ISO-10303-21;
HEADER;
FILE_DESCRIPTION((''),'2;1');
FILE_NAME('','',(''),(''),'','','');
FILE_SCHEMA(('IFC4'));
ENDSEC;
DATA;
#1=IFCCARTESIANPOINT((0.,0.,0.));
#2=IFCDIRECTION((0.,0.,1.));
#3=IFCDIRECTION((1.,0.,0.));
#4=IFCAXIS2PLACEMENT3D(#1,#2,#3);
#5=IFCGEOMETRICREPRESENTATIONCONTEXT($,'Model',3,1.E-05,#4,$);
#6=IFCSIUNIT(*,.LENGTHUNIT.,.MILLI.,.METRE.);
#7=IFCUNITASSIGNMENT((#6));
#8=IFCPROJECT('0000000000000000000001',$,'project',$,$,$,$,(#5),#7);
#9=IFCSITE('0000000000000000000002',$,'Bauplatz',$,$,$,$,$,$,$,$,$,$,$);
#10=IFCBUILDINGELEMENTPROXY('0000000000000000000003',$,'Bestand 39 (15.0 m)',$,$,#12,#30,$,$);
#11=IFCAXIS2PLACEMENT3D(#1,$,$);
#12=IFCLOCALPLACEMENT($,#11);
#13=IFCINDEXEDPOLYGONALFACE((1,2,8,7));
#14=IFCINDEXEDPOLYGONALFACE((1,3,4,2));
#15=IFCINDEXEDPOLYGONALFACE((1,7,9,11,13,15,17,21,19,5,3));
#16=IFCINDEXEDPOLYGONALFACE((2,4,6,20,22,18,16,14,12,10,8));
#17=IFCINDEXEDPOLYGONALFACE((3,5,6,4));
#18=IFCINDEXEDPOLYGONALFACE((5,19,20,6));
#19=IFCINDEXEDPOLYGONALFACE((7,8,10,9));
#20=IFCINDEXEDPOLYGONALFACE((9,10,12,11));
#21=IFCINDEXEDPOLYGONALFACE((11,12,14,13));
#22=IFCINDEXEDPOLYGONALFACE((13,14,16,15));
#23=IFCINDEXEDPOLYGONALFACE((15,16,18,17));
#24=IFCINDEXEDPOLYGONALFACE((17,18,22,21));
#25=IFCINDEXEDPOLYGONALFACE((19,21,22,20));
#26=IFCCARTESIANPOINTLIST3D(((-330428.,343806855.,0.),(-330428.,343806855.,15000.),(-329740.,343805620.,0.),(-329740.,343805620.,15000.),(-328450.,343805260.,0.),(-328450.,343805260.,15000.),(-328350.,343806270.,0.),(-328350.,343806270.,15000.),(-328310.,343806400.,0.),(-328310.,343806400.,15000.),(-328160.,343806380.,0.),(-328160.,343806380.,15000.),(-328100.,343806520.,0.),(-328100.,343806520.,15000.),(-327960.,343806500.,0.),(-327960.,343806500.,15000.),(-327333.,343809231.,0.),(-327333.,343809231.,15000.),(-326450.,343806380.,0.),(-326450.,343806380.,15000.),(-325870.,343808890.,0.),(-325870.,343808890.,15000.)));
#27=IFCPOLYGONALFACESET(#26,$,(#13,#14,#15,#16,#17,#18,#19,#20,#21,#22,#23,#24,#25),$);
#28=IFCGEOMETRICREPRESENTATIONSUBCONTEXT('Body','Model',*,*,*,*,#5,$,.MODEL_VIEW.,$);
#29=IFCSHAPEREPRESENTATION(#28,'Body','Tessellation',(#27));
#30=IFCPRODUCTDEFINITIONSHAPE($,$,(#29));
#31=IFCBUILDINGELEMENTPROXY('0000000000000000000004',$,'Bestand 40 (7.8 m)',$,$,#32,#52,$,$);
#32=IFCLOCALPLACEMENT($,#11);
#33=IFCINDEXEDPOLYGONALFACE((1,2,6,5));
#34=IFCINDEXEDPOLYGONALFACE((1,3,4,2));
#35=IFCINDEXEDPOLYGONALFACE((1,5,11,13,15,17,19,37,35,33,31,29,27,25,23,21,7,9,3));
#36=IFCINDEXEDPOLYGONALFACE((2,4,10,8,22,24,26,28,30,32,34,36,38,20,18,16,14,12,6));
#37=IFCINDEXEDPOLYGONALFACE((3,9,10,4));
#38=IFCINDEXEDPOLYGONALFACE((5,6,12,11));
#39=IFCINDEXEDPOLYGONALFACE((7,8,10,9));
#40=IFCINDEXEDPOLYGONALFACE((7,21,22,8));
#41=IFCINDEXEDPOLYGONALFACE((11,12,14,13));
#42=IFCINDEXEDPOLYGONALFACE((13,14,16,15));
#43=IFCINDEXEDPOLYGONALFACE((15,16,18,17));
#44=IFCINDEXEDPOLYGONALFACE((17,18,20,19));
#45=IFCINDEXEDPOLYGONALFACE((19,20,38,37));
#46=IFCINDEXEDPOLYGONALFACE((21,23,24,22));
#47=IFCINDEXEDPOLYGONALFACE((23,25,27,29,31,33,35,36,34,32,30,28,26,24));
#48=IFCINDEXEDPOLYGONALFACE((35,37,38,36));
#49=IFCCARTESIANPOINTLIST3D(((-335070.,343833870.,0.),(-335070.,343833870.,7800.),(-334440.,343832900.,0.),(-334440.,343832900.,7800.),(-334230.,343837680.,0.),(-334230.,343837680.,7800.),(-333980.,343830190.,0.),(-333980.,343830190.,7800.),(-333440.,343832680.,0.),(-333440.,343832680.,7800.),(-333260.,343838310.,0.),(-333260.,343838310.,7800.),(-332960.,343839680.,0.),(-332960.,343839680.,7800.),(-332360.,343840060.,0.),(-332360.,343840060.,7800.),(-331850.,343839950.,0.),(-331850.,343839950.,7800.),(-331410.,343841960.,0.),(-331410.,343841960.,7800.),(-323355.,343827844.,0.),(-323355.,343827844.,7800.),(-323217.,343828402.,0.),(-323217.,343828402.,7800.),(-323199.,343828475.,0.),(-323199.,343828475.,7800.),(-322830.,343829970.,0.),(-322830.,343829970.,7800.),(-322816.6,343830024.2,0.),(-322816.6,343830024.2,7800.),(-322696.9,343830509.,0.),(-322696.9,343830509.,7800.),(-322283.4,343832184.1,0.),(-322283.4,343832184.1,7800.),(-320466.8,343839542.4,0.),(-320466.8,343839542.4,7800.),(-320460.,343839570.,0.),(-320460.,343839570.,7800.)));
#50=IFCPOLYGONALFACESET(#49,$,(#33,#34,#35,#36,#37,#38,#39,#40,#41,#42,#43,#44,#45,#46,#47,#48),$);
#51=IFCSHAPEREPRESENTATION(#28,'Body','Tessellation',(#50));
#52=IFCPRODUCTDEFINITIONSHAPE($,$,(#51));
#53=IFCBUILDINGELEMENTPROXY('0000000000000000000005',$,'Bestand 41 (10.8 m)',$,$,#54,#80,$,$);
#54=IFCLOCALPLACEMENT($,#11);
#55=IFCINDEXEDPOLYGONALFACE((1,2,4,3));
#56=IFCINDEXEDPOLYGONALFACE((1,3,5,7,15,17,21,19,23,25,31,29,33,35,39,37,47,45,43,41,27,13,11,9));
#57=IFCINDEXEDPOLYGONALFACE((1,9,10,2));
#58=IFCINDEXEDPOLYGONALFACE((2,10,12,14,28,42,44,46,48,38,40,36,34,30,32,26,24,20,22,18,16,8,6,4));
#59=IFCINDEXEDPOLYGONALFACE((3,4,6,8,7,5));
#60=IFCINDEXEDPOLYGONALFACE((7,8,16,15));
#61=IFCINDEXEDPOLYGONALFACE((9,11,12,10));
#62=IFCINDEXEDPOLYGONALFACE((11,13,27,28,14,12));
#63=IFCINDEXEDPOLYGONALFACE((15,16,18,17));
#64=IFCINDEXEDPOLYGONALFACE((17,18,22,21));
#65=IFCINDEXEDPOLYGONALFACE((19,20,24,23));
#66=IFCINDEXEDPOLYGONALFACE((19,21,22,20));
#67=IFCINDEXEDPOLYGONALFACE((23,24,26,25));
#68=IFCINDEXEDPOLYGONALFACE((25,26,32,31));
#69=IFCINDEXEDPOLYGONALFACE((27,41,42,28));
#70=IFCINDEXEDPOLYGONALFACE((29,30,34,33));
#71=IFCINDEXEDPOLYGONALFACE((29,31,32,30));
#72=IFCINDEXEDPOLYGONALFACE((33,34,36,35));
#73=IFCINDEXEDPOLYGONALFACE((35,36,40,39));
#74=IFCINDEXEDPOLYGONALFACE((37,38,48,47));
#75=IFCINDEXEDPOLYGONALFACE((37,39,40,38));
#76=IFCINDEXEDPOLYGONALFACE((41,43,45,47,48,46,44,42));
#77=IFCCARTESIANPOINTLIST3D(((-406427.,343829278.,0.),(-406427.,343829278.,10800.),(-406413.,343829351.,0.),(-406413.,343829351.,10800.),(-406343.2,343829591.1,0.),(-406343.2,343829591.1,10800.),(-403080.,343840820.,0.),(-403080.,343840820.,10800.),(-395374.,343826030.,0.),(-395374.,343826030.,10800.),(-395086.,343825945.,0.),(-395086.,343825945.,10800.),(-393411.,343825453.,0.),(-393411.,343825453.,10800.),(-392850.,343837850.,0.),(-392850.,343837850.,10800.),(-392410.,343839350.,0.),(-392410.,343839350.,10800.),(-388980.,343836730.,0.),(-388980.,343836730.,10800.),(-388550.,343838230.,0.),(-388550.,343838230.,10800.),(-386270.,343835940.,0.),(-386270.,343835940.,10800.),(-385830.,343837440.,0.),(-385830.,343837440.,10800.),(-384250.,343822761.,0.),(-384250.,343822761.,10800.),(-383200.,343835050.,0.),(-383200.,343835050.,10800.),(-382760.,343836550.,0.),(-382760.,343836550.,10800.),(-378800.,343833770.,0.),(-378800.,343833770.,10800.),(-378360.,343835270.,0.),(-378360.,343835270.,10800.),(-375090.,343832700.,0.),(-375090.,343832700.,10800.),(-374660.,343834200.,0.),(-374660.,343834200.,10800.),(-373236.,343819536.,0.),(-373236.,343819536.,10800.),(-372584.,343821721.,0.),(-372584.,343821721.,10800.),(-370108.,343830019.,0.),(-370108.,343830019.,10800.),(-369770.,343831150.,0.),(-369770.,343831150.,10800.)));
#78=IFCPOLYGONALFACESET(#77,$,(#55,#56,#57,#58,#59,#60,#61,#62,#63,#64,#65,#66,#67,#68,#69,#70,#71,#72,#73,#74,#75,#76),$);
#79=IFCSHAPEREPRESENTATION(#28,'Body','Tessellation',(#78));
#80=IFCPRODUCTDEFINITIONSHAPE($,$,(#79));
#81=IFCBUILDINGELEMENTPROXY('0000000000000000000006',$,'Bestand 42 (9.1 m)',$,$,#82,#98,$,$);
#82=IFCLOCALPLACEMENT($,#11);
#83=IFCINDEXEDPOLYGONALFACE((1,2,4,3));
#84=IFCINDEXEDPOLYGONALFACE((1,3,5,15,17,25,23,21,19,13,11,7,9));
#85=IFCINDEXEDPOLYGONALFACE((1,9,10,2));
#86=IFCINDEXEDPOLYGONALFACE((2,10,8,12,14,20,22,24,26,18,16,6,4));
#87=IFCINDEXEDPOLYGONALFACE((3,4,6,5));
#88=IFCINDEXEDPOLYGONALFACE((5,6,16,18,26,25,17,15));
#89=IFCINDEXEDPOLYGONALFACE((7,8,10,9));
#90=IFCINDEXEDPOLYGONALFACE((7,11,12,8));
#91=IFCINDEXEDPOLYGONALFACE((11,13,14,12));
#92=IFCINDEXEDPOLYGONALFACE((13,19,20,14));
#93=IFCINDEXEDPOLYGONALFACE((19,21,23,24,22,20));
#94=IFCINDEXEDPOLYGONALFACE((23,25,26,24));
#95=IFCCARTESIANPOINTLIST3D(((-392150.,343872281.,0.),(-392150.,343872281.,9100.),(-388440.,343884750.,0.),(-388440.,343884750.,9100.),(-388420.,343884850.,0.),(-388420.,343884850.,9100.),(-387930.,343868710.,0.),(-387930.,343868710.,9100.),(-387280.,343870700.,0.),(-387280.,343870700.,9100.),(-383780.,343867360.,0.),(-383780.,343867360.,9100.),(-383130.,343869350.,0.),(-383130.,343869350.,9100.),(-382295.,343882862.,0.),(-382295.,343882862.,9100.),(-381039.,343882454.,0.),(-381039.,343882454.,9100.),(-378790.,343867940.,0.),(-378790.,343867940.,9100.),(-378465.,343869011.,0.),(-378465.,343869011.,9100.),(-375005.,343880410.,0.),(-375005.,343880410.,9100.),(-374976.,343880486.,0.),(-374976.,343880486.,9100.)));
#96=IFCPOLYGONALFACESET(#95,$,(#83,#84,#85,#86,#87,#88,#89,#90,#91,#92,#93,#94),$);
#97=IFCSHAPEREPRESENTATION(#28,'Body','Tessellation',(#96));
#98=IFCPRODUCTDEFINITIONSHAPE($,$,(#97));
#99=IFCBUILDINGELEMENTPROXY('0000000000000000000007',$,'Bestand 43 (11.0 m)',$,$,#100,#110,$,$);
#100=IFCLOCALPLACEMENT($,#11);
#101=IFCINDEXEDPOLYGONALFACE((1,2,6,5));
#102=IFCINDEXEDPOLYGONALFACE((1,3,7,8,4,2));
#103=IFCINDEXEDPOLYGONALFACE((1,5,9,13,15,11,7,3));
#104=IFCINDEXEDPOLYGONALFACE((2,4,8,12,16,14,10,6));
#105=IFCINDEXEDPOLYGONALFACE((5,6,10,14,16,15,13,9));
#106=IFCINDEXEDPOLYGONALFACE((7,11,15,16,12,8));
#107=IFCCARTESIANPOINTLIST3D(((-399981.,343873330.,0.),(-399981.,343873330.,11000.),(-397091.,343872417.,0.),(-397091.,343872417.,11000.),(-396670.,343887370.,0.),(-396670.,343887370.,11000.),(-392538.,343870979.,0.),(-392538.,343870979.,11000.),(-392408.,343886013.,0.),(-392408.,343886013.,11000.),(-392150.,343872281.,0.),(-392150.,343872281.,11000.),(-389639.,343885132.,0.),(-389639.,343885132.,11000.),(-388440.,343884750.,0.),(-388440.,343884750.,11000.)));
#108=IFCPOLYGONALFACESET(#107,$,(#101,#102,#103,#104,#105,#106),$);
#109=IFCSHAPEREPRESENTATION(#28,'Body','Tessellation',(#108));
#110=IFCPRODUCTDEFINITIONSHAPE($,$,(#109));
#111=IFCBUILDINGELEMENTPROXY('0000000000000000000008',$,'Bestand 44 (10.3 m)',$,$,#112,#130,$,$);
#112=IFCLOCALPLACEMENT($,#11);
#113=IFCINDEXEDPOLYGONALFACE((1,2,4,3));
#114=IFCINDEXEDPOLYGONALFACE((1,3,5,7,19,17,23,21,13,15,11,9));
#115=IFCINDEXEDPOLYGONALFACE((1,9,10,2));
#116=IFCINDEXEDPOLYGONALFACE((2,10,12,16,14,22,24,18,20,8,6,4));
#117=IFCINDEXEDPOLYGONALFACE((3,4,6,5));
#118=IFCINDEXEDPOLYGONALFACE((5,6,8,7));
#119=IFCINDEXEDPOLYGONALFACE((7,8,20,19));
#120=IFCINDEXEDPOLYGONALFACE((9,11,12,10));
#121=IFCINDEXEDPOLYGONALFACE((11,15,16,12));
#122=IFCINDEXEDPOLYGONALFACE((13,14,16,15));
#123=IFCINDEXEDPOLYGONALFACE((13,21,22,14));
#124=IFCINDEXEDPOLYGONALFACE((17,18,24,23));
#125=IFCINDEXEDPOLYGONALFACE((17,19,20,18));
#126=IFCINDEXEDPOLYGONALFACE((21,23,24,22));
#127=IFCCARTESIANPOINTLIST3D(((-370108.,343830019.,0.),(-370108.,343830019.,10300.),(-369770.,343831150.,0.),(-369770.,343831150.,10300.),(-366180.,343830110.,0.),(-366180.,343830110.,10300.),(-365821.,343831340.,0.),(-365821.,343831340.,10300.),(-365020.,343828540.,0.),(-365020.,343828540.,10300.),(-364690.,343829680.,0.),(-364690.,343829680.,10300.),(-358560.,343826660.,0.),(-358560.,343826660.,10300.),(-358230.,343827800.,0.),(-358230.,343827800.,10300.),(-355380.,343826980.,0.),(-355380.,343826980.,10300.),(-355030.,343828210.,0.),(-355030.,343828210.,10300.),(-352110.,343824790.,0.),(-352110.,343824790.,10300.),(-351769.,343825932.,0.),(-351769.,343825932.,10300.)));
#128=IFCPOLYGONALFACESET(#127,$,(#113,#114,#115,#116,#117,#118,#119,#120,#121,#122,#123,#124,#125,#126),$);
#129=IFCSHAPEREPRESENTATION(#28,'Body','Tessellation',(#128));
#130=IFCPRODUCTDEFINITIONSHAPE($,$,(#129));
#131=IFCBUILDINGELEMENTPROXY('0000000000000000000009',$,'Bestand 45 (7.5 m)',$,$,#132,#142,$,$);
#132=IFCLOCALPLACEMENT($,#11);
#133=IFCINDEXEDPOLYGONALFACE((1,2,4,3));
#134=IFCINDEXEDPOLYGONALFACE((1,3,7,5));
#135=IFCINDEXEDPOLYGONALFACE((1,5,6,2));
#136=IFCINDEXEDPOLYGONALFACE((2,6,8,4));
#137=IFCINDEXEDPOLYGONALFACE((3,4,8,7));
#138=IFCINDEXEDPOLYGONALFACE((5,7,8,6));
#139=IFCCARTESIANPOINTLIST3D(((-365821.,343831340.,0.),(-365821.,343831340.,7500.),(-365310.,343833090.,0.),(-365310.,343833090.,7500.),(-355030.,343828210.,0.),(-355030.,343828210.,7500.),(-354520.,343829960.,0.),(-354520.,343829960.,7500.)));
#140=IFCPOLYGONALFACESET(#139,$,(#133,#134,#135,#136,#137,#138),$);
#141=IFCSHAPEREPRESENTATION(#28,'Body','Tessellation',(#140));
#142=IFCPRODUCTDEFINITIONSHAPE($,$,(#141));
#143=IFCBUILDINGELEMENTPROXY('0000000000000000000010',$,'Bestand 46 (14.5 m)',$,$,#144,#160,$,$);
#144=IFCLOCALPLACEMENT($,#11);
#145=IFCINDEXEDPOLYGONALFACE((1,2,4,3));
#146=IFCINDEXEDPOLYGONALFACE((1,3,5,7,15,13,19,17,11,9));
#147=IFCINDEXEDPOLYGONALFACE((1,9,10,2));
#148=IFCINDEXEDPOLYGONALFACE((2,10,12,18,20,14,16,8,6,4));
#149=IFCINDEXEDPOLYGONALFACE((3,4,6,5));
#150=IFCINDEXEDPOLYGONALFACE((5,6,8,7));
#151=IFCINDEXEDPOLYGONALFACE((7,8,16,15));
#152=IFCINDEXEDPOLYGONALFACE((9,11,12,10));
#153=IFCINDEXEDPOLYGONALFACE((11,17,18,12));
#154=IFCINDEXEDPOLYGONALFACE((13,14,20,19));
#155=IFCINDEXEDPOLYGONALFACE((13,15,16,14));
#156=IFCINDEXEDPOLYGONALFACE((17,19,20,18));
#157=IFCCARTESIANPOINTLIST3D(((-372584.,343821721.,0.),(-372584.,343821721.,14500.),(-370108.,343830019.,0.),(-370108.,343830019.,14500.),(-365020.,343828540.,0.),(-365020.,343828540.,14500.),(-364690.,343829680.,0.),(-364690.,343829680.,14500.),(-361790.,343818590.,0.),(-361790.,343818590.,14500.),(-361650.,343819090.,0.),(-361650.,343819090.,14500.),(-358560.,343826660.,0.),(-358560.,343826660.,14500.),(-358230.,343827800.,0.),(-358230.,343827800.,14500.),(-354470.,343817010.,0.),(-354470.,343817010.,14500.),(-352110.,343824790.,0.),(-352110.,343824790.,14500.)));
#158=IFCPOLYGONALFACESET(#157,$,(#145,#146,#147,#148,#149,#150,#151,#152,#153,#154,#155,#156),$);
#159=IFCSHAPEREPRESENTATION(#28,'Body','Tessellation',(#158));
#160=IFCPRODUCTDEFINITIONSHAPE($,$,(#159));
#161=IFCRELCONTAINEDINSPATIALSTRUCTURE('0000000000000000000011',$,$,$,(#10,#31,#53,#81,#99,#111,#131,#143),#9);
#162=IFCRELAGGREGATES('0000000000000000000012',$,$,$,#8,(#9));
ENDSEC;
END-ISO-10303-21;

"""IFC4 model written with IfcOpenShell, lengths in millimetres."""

from ifc_helpers import new_model, si_unit, origin_with_axes, place, context, subcontext, project, spatial, indexed_curve, outline, extrude, element, save


model = new_model("IFC4")

# Units and contexts
model_context = context("Model", 3, precision=1e-05, world=origin_with_axes())
body_context = subcontext(model_context, "Body", "Model", "MODEL_VIEW")
ifc_project = project(units=[si_unit("LENGTHUNIT", "METRE", prefix="MILLI")], contexts=[model_context])

# Site
site = spatial("IfcSite", under=ifc_project, Name="Bauplatz")

# Building element proxies
proxy_1_placement = place(None, origin_with_axes())
element("IfcBuildingElementProxy", 1, at=proxy_1_placement, inside=site, Name="Bestand 39 (15.0 m)", context=body_context, shape_type="SweptSolid", body=[
    extrude(outline(indexed_curve([(-325870.0, 343808890.0), (-327333.0, 343809231.0), (-327960.0, 343806500.0), (-328100.0, 343806520.0), (-328160.0, 343806380.0), (-328310.0, 343806400.0), (-328350.0, 343806270.0), (-330428.0, 343806855.0), (-329740.0, 343805620.0), (-328450.0, 343805260.0), (-326450.0, 343806380.0)])), None, (0.0, 0.0, 1.0), 15000.0),
])
proxy_2_placement = place(None, origin_with_axes())
element("IfcBuildingElementProxy", 2, at=proxy_2_placement, inside=site, Name="Bestand 40 (7.8 m)", context=body_context, shape_type="SweptSolid", body=[
    extrude(outline(indexed_curve([(-320460.0, 343839570.0), (-331410.0, 343841960.0), (-331850.0, 343839950.0), (-332360.0, 343840060.0), (-332960.0, 343839680.0), (-333260.0, 343838310.0), (-334230.0, 343837680.0), (-335070.0, 343833870.0), (-334440.0, 343832900.0), (-333440.0, 343832680.0), (-333980.0, 343830190.0), (-323355.0, 343827844.0), (-323217.0, 343828402.0), (-323199.0, 343828475.0), (-322830.0, 343829970.0), (-322816.6, 343830024.2), (-322696.9, 343830509.0), (-322283.4, 343832184.1), (-320466.8, 343839542.4)])), None, (0.0, 0.0, 1.0), 7800.0),
])
proxy_3_placement = place(None, origin_with_axes())
element("IfcBuildingElementProxy", 3, at=proxy_3_placement, inside=site, Name="Bestand 41 (10.8 m)", context=body_context, shape_type="SweptSolid", body=[
    extrude(outline(indexed_curve([(-392850.0, 343837850.0), (-403080.0, 343840820.0), (-406343.2, 343829591.1), (-406413.0, 343829351.0), (-406427.0, 343829278.0), (-395374.0, 343826030.0), (-395086.0, 343825945.0), (-393411.0, 343825453.0), (-384250.0, 343822761.0), (-373236.0, 343819536.0), (-372584.0, 343821721.0), (-370108.0, 343830019.0), (-369770.0, 343831150.0), (-375090.0, 343832700.0), (-374660.0, 343834200.0), (-378360.0, 343835270.0), (-378800.0, 343833770.0), (-383200.0, 343835050.0), (-382760.0, 343836550.0), (-385830.0, 343837440.0), (-386270.0, 343835940.0), (-388980.0, 343836730.0), (-388550.0, 343838230.0), (-392410.0, 343839350.0)])), None, (0.0, 0.0, 1.0), 10800.0),
])
proxy_4_placement = place(None, origin_with_axes())
element("IfcBuildingElementProxy", 4, at=proxy_4_placement, inside=site, Name="Bestand 42 (9.1 m)", context=body_context, shape_type="SweptSolid", body=[
    extrude(outline(indexed_curve([(-382295.0, 343882862.0), (-388420.0, 343884850.0), (-388440.0, 343884750.0), (-392150.0, 343872281.0), (-387280.0, 343870700.0), (-387930.0, 343868710.0), (-383780.0, 343867360.0), (-383130.0, 343869350.0), (-378790.0, 343867940.0), (-378465.0, 343869011.0), (-375005.0, 343880410.0), (-374976.0, 343880486.0), (-381039.0, 343882454.0)])), None, (0.0, 0.0, 1.0), 9100.0),
])
proxy_5_placement = place(None, origin_with_axes())
element("IfcBuildingElementProxy", 5, at=proxy_5_placement, inside=site, Name="Bestand 43 (11.0 m)", context=body_context, shape_type="SweptSolid", body=[
    extrude(outline(indexed_curve([(-392408.0, 343886013.0), (-396670.0, 343887370.0), (-399981.0, 343873330.0), (-397091.0, 343872417.0), (-392538.0, 343870979.0), (-392150.0, 343872281.0), (-388440.0, 343884750.0), (-389639.0, 343885132.0)])), None, (0.0, 0.0, 1.0), 11000.0),
])
proxy_6_placement = place(None, origin_with_axes())
element("IfcBuildingElementProxy", 6, at=proxy_6_placement, inside=site, Name="Bestand 44 (10.3 m)", context=body_context, shape_type="SweptSolid", body=[
    extrude(outline(indexed_curve([(-355030.0, 343828210.0), (-365821.0, 343831340.0), (-366180.0, 343830110.0), (-369770.0, 343831150.0), (-370108.0, 343830019.0), (-365020.0, 343828540.0), (-364690.0, 343829680.0), (-358230.0, 343827800.0), (-358560.0, 343826660.0), (-352110.0, 343824790.0), (-351769.0, 343825932.0), (-355380.0, 343826980.0)])), None, (0.0, 0.0, 1.0), 10300.0),
])
proxy_7_placement = place(None, origin_with_axes())
element("IfcBuildingElementProxy", 7, at=proxy_7_placement, inside=site, Name="Bestand 45 (7.5 m)", context=body_context, shape_type="SweptSolid", body=[
    extrude(outline(indexed_curve([(-354520.0, 343829960.0), (-365310.0, 343833090.0), (-365821.0, 343831340.0), (-355030.0, 343828210.0)])), None, (0.0, 0.0, 1.0), 7500.0),
])
proxy_8_placement = place(None, origin_with_axes())
element("IfcBuildingElementProxy", 8, at=proxy_8_placement, inside=site, Name="Bestand 46 (14.5 m)", context=body_context, shape_type="SweptSolid", body=[
    extrude(outline(indexed_curve([(-365020.0, 343828540.0), (-370108.0, 343830019.0), (-372584.0, 343821721.0), (-361790.0, 343818590.0), (-361650.0, 343819090.0), (-354470.0, 343817010.0), (-352110.0, 343824790.0), (-358560.0, 343826660.0), (-358230.0, 343827800.0), (-364690.0, 343829680.0)])), None, (0.0, 0.0, 1.0), 14500.0),
])

save(model, "model.ifc")
